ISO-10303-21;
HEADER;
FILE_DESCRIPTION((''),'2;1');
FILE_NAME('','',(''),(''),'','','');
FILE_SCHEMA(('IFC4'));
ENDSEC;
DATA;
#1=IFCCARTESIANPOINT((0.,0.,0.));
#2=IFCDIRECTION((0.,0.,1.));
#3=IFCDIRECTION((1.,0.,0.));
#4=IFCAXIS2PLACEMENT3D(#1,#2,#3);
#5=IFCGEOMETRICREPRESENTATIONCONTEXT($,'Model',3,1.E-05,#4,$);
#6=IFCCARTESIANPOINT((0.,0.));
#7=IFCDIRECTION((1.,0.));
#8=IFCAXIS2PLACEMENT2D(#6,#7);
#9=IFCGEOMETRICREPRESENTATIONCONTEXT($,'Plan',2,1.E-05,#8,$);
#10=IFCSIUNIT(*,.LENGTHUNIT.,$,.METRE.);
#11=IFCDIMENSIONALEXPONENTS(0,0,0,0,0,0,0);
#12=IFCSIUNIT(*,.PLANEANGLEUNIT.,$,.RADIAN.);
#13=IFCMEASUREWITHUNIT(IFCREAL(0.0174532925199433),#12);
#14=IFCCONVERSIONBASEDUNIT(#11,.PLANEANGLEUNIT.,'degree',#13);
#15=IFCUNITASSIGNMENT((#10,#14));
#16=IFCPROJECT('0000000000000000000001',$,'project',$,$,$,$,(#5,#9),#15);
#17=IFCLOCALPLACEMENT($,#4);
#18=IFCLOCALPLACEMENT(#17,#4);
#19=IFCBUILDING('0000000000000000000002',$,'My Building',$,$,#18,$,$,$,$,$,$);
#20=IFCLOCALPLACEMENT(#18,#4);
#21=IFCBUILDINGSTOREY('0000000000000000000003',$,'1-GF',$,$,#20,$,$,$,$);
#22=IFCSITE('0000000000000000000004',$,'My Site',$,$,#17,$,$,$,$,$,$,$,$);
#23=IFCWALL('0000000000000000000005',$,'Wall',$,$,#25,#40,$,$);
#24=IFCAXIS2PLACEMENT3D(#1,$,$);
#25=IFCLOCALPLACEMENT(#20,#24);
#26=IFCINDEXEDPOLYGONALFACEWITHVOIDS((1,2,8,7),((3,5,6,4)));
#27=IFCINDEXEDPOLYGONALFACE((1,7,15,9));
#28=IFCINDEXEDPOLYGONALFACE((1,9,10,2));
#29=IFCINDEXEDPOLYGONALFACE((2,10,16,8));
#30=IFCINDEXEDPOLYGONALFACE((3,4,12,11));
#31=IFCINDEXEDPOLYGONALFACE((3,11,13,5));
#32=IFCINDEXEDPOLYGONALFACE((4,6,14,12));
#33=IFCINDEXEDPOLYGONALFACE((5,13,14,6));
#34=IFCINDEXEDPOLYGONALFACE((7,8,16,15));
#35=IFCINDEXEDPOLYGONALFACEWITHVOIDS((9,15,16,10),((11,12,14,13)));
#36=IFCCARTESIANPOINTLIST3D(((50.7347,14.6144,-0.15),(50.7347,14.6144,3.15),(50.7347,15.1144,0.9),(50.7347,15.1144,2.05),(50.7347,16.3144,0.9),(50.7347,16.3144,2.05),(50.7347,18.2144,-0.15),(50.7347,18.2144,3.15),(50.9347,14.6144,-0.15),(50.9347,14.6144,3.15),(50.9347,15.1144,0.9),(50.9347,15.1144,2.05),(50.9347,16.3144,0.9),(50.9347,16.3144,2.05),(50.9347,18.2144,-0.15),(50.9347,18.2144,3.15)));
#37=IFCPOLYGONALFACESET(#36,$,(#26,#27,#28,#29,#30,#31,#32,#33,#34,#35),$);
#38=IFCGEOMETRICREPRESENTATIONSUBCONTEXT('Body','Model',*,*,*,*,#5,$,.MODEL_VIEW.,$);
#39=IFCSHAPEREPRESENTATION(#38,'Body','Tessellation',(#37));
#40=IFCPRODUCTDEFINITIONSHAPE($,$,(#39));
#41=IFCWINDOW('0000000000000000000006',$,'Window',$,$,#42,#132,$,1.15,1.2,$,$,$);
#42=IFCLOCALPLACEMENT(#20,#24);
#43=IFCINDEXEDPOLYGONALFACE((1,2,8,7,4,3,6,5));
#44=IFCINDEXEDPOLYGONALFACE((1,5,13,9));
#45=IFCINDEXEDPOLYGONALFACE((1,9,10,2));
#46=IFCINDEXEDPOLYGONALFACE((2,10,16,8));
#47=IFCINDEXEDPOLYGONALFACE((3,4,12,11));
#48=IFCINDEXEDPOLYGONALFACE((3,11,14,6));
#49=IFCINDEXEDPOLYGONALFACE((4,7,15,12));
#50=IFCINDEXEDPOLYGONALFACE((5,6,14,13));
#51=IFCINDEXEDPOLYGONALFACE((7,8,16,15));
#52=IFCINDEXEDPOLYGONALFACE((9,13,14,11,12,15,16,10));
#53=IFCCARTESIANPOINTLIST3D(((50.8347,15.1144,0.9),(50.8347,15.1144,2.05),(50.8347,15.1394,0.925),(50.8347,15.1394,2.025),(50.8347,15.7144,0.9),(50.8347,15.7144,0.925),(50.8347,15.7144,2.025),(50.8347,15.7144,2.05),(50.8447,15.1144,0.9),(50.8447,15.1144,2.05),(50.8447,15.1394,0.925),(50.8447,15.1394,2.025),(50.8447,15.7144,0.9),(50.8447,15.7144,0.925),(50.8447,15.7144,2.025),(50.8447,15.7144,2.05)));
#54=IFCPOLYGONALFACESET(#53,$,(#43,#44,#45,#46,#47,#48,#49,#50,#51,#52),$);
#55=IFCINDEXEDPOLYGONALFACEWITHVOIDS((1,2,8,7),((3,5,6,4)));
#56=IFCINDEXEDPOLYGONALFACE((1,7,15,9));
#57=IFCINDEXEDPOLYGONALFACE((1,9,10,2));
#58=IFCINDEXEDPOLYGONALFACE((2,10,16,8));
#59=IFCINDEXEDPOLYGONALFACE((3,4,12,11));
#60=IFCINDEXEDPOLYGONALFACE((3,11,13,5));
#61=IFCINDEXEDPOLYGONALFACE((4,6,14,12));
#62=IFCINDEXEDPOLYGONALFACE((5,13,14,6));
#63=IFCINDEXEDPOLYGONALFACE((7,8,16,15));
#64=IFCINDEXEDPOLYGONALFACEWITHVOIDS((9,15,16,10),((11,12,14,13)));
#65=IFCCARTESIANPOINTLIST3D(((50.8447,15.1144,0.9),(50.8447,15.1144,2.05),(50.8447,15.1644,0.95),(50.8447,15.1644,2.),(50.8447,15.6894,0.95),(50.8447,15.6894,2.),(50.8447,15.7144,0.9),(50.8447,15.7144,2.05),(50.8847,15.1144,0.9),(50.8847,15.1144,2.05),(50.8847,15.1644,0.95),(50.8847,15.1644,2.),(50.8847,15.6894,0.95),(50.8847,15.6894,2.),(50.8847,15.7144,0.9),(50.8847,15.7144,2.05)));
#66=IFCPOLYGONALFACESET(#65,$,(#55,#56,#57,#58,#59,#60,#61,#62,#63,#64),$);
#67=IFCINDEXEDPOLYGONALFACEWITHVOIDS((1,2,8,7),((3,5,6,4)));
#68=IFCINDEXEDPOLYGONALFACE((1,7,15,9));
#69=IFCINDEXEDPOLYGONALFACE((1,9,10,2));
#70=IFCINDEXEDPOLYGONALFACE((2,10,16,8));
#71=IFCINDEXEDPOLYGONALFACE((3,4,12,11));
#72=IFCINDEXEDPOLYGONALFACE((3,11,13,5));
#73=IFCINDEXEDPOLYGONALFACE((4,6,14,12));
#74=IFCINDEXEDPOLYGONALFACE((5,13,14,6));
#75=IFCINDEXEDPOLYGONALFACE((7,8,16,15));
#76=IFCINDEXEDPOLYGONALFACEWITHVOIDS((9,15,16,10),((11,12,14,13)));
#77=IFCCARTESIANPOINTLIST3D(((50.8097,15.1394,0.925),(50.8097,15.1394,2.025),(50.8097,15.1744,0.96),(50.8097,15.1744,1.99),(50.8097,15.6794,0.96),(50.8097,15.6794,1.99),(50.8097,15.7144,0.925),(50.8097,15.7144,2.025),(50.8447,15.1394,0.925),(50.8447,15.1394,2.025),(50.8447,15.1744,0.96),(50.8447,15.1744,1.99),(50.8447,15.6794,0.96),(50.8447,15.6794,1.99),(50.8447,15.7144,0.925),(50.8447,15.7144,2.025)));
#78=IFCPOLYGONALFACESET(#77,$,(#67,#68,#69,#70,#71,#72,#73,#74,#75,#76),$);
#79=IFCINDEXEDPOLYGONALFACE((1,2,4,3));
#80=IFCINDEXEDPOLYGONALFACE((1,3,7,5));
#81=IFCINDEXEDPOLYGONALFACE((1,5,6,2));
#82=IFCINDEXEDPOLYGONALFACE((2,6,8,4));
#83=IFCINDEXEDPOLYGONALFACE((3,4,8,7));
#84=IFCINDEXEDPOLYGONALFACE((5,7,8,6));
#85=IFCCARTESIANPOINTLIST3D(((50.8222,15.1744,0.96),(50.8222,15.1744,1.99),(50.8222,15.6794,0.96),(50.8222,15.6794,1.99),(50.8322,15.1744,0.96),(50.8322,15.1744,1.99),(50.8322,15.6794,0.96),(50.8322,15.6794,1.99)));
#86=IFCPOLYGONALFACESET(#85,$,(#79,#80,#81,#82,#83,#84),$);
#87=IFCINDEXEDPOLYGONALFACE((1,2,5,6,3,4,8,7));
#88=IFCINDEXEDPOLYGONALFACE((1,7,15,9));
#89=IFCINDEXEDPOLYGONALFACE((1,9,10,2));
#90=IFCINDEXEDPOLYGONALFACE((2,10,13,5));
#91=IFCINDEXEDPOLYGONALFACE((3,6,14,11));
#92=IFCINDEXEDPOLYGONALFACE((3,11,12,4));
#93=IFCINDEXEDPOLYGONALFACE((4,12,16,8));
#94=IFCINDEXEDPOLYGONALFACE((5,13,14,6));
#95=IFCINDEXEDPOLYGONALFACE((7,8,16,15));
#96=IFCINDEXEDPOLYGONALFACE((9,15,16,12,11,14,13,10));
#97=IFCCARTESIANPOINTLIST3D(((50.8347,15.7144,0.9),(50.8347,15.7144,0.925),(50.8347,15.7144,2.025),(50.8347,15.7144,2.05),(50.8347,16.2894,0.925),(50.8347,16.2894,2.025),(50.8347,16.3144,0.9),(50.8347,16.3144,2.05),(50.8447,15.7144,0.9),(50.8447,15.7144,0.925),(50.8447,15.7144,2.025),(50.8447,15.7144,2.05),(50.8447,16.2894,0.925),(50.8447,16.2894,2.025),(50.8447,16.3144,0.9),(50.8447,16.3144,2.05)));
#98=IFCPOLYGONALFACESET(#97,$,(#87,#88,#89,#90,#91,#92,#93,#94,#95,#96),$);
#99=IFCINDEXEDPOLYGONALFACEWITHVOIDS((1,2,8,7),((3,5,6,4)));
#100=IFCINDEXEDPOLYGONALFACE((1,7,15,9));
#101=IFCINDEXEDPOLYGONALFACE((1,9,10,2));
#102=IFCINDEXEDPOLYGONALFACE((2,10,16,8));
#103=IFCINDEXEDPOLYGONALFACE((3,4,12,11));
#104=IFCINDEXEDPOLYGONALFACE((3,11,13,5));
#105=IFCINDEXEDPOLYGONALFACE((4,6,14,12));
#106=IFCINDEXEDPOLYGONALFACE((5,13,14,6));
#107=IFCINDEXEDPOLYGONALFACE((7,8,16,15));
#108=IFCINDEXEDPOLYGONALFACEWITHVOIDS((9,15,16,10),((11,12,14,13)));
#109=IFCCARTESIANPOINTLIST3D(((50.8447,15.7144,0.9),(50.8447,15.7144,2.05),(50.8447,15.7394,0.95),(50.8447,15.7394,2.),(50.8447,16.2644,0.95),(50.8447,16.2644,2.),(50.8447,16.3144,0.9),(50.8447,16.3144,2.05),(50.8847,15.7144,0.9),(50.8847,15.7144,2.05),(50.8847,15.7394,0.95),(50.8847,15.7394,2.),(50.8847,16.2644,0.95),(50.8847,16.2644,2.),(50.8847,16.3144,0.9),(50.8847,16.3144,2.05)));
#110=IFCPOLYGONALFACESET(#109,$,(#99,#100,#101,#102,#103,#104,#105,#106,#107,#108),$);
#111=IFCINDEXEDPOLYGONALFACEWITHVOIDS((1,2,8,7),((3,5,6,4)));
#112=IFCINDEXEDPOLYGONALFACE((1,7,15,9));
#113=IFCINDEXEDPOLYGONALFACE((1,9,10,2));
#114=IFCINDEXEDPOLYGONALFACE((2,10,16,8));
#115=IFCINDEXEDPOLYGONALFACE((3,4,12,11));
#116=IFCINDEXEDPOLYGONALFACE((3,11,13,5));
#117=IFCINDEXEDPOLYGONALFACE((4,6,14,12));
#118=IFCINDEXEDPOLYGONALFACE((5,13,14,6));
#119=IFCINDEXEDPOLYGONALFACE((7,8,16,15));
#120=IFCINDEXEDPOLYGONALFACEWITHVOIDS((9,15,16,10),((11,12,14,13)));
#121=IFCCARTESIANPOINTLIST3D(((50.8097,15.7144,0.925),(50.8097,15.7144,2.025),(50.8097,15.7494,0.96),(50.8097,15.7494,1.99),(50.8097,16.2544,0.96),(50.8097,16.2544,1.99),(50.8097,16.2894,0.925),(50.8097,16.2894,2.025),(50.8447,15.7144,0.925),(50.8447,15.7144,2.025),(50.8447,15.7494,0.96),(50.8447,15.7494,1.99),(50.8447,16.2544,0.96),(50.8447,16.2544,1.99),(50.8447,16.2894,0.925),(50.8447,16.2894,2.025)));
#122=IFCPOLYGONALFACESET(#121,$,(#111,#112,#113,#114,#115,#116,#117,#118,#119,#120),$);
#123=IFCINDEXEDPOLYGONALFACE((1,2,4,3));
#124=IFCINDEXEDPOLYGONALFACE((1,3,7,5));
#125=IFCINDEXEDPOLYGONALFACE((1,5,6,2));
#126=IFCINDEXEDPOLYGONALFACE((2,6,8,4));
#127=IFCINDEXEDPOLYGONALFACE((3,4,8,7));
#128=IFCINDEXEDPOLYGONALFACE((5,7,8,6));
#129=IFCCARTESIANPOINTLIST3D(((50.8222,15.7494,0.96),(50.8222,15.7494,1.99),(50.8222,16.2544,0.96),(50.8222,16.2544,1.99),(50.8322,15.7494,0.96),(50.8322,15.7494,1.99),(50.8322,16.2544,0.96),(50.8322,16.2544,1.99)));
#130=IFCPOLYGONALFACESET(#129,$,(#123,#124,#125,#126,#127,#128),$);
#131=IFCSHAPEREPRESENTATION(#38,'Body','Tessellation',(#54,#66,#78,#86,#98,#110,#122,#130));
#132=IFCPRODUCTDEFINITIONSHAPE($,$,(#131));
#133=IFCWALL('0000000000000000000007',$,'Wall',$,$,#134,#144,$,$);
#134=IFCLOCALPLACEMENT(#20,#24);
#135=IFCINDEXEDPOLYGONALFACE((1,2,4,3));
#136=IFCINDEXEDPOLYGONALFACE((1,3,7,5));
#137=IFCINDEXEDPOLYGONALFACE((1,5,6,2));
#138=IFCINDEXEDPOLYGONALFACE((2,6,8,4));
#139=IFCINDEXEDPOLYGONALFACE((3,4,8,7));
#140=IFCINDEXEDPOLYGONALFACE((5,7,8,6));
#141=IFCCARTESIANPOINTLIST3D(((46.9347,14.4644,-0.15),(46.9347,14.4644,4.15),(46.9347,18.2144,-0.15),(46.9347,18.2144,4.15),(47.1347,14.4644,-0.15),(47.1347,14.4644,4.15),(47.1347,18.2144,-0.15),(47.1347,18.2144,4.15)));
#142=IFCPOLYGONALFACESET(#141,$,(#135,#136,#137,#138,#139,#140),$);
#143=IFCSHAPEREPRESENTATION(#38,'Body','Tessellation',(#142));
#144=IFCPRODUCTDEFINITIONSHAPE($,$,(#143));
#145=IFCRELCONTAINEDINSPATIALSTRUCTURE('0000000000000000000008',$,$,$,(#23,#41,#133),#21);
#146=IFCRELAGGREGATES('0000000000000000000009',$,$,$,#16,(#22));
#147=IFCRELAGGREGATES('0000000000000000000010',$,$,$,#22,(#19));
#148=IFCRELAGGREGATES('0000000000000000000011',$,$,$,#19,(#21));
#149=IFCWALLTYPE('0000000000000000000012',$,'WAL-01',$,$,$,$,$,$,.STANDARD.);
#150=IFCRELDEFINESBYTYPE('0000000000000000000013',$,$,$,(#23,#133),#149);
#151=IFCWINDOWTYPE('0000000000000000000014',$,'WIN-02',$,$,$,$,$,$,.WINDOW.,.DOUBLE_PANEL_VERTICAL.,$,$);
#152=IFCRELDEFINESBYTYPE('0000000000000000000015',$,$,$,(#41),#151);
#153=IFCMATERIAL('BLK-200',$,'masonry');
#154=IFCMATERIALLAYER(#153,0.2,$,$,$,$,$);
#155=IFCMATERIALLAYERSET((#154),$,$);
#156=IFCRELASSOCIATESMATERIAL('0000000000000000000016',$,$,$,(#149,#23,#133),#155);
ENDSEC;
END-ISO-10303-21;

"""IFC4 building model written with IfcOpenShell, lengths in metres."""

from ifc_helpers import new_model, entity, si_unit, converted_unit, frame, origin_with_axes, origin_2d_with_axis, place, context, subcontext, project, spatial, line, indexed_curve, outline, extrude, shape, source, transform, mapped, material, layer, layer_set, layer_usage, type_object, type_shapes, element, fill, save


model = new_model("IFC4")

# Units and contexts
model_context = context("Model", 3, precision=1e-05, world=origin_with_axes())
plan_context = context("Plan", 2, precision=1e-05, world=origin_2d_with_axis())
body_context_1 = subcontext(model_context, "Body", "Model", "MODEL_VIEW")
body_context_2 = subcontext(plan_context, "Body", "Plan", "PLAN_VIEW")
ifc_project = project(units=[si_unit("LENGTHUNIT", "METRE"), converted_unit("PLANEANGLEUNIT", "degree", entity("IfcReal", 0.0174532925199433), si_unit("PLANEANGLEUNIT", "RADIAN"), dimensions=[0, 0, 0, 0, 0, 0, 0])], contexts=[model_context, plan_context])

# Site, building, storey
site_placement = place(None, origin_with_axes())
site = spatial("IfcSite", under=ifc_project, at=site_placement, Name="My Site")
building_placement = place(site_placement, origin_with_axes())
building = spatial("IfcBuilding", under=site, at=building_placement, Name="My Building")
storey_placement = place(building_placement, origin_with_axes())
storey = spatial("IfcBuildingStorey", under=building, at=storey_placement, Name="1-GF")

# Shared definitions
ifc_material_1 = material(Name="BLK-200", Category="masonry")
ifc_layer_1 = layer(ifc_material_1, 0.2)
ifc_layer_set_1 = layer_set([ifc_layer_1])
wall_type_1 = type_object("IfcWallType", Name="WAL-01", PredefinedType="STANDARD", material=ifc_layer_set_1)
shared_shape_1 = source(origin_with_axes(), body_context_1, "Body", "SweptSolid", [
    extrude(outline(indexed_curve([(0.0, 0.0), (1.2, 0.0), (1.2, 1.15), (0.0, 1.15)], segments=[line(1, 2, 3, 4, 1)])), frame((0.0, -0.6, 0.0), z_axis=(0.0, -1.0, 0.0), x_axis=(1.0, 0.0, 0.0)), (0.0, 0.0, -1.0), 1.2),
])
window_type_1 = type_object("IfcWindowType", Name="WIN-02", PartitioningType="DOUBLE_PANEL_VERTICAL", PredefinedType="WINDOW")
shared_shape_2 = source(origin_with_axes(), body_context_1, "Body", "SweptSolid", [
    extrude(outline(indexed_curve([(0.6, 0.0), (0.0, 0.0), (0.0, 1.15), (0.6, 1.15), (0.6, 1.125), (0.025, 1.125), (0.025, 0.025), (0.6, 0.025)], segments=[line(1, 2, 3, 4, 5, 6, 7, 8, 1)])), frame((0.0, 0.09, 0.0), z_axis=(0.0, -1.0, 0.0), x_axis=(1.0, 0.0, 0.0)), (0.0, 0.0, -1.0), 0.01),
    extrude(outline(indexed_curve([(0.0, 0.0), (0.6, 0.0), (0.6, 1.15), (0.0, 1.15)], segments=[line(1, 2, 3, 4, 1)]), holes=[indexed_curve([(0.05, 0.05), (0.575, 0.05), (0.575, 1.1), (0.05, 1.1)], segments=[line(1, 2, 3, 4, 1)])]), frame((0.0, 0.05, 0.0), z_axis=(0.0, -1.0, 0.0), x_axis=(1.0, 0.0, 0.0)), (0.0, 0.0, -1.0), 0.04),
    extrude(outline(indexed_curve([(0.0, 0.0), (0.575, 0.0), (0.575, 1.1), (0.0, 1.1)], segments=[line(1, 2, 3, 4, 1)]), holes=[indexed_curve([(0.035, 0.035), (0.54, 0.035), (0.54, 1.065), (0.035, 1.065)], segments=[line(1, 2, 3, 4, 1)])]), frame((0.025, 0.09, 0.025), z_axis=(0.0, -1.0, 0.0), x_axis=(1.0, 0.0, 0.0)), (0.0, 0.0, -1.0), 0.035),
    extrude(outline(indexed_curve([(0.035, 0.035), (0.54, 0.035), (0.54, 1.065), (0.035, 1.065)], segments=[line(1, 2, 3, 4, 1)])), frame((0.025, 0.1025, 0.025), z_axis=(0.0, -1.0, 0.0), x_axis=(1.0, 0.0, 0.0)), (0.0, 0.0, -1.0), 0.01),
    extrude(outline(indexed_curve([(0.0, 1.15), (0.6, 1.15), (0.6, 0.0), (0.0, 0.0), (0.0, 0.025), (0.575, 0.025), (0.575, 1.125), (0.0, 1.125)], segments=[line(1, 2, 3, 4, 5, 6, 7, 8, 1)])), frame((0.6, 0.09, 0.0), z_axis=(0.0, -1.0, 0.0), x_axis=(1.0, 0.0, 0.0)), (0.0, 0.0, -1.0), 0.01),
    extrude(outline(indexed_curve([(0.0, 0.0), (0.6, 0.0), (0.6, 1.15), (0.0, 1.15)], segments=[line(1, 2, 3, 4, 1)]), holes=[indexed_curve([(0.025, 0.05), (0.55, 0.05), (0.55, 1.1), (0.025, 1.1)], segments=[line(1, 2, 3, 4, 1)])]), frame((0.6, 0.05, 0.0), z_axis=(0.0, -1.0, 0.0), x_axis=(1.0, 0.0, 0.0)), (0.0, 0.0, -1.0), 0.04),
    extrude(outline(indexed_curve([(0.0, 0.0), (0.575, 0.0), (0.575, 1.1), (0.0, 1.1)], segments=[line(1, 2, 3, 4, 1)]), holes=[indexed_curve([(0.035, 0.035), (0.54, 0.035), (0.54, 1.065), (0.035, 1.065)], segments=[line(1, 2, 3, 4, 1)])]), frame((0.6, 0.09, 0.025), z_axis=(0.0, -1.0, 0.0), x_axis=(1.0, 0.0, 0.0)), (0.0, 0.0, -1.0), 0.035),
    extrude(outline(indexed_curve([(0.035, 0.035), (0.54, 0.035), (0.54, 1.065), (0.035, 1.065)], segments=[line(1, 2, 3, 4, 1)])), frame((0.6, 0.1025, 0.025), z_axis=(0.0, -1.0, 0.0), x_axis=(1.0, 0.0, 0.0)), (0.0, 0.0, -1.0), 0.01),
])
shared_shape_3 = source(origin_with_axes(), body_context_2, "Body", "Curve2D", [
    entity("IfcIndexedPolyCurve", entity("IfcCartesianPointList2D", [[0.05, 0.05], [0.575, 0.05]])),
    entity("IfcIndexedPolyCurve", entity("IfcCartesianPointList2D", [[0.0, 0.1], [0.025, 0.1], [0.025, 0.09], [0.05, 0.09], [0.05, 0.05], [0.0, 0.05]]), [entity("IfcLineIndex", [1, 2, 3, 4, 5, 6, 1])]),
    entity("IfcIndexedPolyCurve", entity("IfcCartesianPointList2D", [[0.6, 0.1], [0.6, 0.1], [0.6, 0.09], [0.575, 0.09], [0.575, 0.05], [0.6, 0.05]])),
    entity("IfcIndexedPolyCurve", entity("IfcCartesianPointList2D", [[0.025, 0.09], [0.06, 0.09], [0.06, 0.125], [0.025, 0.125]]), [entity("IfcLineIndex", [1, 2, 3, 4, 1])]),
    entity("IfcIndexedPolyCurve", entity("IfcCartesianPointList2D", [[0.6, 0.09], [0.565, 0.09], [0.565, 0.125], [0.6, 0.125]]), [entity("IfcLineIndex", [1, 2, 3, 4, 1])]),
    entity("IfcIndexedPolyCurve", entity("IfcCartesianPointList2D", [[0.06, 0.09], [0.565, 0.09]])),
    entity("IfcIndexedPolyCurve", entity("IfcCartesianPointList2D", [[0.06, 0.125], [0.565, 0.125]])),
    entity("IfcIndexedPolyCurve", entity("IfcCartesianPointList2D", [[0.06, 0.1075], [0.565, 0.1075]])),
    entity("IfcIndexedPolyCurve", entity("IfcCartesianPointList2D", [[0.625, 0.05], [1.15, 0.05]])),
    entity("IfcIndexedPolyCurve", entity("IfcCartesianPointList2D", [[0.6, 0.1], [0.6, 0.1], [0.6, 0.09], [0.625, 0.09], [0.625, 0.05], [0.6, 0.05]])),
    entity("IfcIndexedPolyCurve", entity("IfcCartesianPointList2D", [[1.2, 0.1], [1.175, 0.1], [1.175, 0.09], [1.15, 0.09], [1.15, 0.05], [1.2, 0.05]]), [entity("IfcLineIndex", [1, 2, 3, 4, 5, 6, 1])]),
    entity("IfcIndexedPolyCurve", entity("IfcCartesianPointList2D", [[0.6, 0.09], [0.635, 0.09], [0.635, 0.125], [0.6, 0.125]]), [entity("IfcLineIndex", [1, 2, 3, 4, 1])]),
    entity("IfcIndexedPolyCurve", entity("IfcCartesianPointList2D", [[1.175, 0.09], [1.14, 0.09], [1.14, 0.125], [1.175, 0.125]]), [entity("IfcLineIndex", [1, 2, 3, 4, 1])]),
    entity("IfcIndexedPolyCurve", entity("IfcCartesianPointList2D", [[0.635, 0.09], [1.14, 0.09]])),
    entity("IfcIndexedPolyCurve", entity("IfcCartesianPointList2D", [[0.635, 0.125], [1.14, 0.125]])),
    entity("IfcIndexedPolyCurve", entity("IfcCartesianPointList2D", [[0.635, 0.1075], [1.14, 0.1075]])),
])
type_shapes(window_type_1, [shared_shape_2, shared_shape_3])

# Wall, opening, window
ifc_layer_usage_1 = layer_usage(ifc_layer_set_1, "AXIS2", "POSITIVE", 0.0)
wall_1_placement = place(storey_placement, frame((50.9347, 14.6144, -0.15), z_axis=(0.0, 0.0, 1.0), x_axis=(0.0, 1.0, 0.0)))
wall_1 = element("IfcWall", 1, at=wall_1_placement, inside=storey, type_object=wall_type_1, material=ifc_layer_usage_1, Name="Wall", context=body_context_1, shape_type="SweptSolid", body=[
    extrude(outline(indexed_curve([(0.0, 0.0), (0.0, 0.2), (3.6, 0.2), (3.6, 0.0), (0.0, 0.0)], self_intersect=False)), origin_with_axes(), (0.0, 0.0, 1.0), 3.3),
])
opening_1_placement = place(wall_1_placement, frame((0.5, 0.0, 1.05), z_axis=(0.0, 0.0, 1.0), x_axis=(1.0, 0.0, 0.0)))
opening_1 = element("IfcOpeningElement", 2, at=opening_1_placement, cuts=wall_1, PredefinedType="OPENING", context=body_context_1, shape_type="MappedRepresentation", body=[
    mapped(shared_shape_1, transform((0.0, 0.0, 0.0), x_axis=(1.0, 0.0, 0.0), y_axis=(0.0, 1.0, 0.0), z_axis=(0.0, 0.0, 1.0), scale=1.0)),
])
window_1_placement = place(opening_1_placement, origin_with_axes())
window_1 = element("IfcWindow", 3, at=window_1_placement, inside=storey, type_object=window_type_1, Name="Window", OverallHeight=1.15, OverallWidth=1.2, shapes=[
    shape(body_context_1, "Body", "MappedRepresentation", [mapped(shared_shape_2, transform((0.0, 0.0, 0.0), x_axis=(1.0, 0.0, 0.0), y_axis=(0.0, 1.0, 0.0), z_axis=(0.0, 0.0, 1.0), scale=1.0))]),
    shape(body_context_2, "Body", "MappedRepresentation", [mapped(shared_shape_3, transform((0.0, 0.0, 0.0), x_axis=(1.0, 0.0, 0.0), y_axis=(0.0, 1.0, 0.0), z_axis=(0.0, 0.0, 1.0), scale=1.0))]),
])
fill(opening_1, window_1)

# Wall
ifc_layer_usage_2 = layer_usage(ifc_layer_set_1, "AXIS2", "POSITIVE", 0.0)
wall_2_placement = place(storey_placement, frame((47.1347, 14.4644, -0.15), z_axis=(0.0, 0.0, 1.0), x_axis=(0.0, 1.0, 0.0)))
element("IfcWall", 4, at=wall_2_placement, inside=storey, type_object=wall_type_1, material=ifc_layer_usage_2, Name="Wall", context=body_context_1, shape_type="SweptSolid", body=[
    extrude(outline(indexed_curve([(0.0, 0.0), (0.0, 0.2), (3.75, 0.2), (3.75, 0.0), (0.0, 0.0)], self_intersect=False)), origin_with_axes(), (0.0, 0.0, 1.0), 4.3),
])

save(model, "model.ifc")
